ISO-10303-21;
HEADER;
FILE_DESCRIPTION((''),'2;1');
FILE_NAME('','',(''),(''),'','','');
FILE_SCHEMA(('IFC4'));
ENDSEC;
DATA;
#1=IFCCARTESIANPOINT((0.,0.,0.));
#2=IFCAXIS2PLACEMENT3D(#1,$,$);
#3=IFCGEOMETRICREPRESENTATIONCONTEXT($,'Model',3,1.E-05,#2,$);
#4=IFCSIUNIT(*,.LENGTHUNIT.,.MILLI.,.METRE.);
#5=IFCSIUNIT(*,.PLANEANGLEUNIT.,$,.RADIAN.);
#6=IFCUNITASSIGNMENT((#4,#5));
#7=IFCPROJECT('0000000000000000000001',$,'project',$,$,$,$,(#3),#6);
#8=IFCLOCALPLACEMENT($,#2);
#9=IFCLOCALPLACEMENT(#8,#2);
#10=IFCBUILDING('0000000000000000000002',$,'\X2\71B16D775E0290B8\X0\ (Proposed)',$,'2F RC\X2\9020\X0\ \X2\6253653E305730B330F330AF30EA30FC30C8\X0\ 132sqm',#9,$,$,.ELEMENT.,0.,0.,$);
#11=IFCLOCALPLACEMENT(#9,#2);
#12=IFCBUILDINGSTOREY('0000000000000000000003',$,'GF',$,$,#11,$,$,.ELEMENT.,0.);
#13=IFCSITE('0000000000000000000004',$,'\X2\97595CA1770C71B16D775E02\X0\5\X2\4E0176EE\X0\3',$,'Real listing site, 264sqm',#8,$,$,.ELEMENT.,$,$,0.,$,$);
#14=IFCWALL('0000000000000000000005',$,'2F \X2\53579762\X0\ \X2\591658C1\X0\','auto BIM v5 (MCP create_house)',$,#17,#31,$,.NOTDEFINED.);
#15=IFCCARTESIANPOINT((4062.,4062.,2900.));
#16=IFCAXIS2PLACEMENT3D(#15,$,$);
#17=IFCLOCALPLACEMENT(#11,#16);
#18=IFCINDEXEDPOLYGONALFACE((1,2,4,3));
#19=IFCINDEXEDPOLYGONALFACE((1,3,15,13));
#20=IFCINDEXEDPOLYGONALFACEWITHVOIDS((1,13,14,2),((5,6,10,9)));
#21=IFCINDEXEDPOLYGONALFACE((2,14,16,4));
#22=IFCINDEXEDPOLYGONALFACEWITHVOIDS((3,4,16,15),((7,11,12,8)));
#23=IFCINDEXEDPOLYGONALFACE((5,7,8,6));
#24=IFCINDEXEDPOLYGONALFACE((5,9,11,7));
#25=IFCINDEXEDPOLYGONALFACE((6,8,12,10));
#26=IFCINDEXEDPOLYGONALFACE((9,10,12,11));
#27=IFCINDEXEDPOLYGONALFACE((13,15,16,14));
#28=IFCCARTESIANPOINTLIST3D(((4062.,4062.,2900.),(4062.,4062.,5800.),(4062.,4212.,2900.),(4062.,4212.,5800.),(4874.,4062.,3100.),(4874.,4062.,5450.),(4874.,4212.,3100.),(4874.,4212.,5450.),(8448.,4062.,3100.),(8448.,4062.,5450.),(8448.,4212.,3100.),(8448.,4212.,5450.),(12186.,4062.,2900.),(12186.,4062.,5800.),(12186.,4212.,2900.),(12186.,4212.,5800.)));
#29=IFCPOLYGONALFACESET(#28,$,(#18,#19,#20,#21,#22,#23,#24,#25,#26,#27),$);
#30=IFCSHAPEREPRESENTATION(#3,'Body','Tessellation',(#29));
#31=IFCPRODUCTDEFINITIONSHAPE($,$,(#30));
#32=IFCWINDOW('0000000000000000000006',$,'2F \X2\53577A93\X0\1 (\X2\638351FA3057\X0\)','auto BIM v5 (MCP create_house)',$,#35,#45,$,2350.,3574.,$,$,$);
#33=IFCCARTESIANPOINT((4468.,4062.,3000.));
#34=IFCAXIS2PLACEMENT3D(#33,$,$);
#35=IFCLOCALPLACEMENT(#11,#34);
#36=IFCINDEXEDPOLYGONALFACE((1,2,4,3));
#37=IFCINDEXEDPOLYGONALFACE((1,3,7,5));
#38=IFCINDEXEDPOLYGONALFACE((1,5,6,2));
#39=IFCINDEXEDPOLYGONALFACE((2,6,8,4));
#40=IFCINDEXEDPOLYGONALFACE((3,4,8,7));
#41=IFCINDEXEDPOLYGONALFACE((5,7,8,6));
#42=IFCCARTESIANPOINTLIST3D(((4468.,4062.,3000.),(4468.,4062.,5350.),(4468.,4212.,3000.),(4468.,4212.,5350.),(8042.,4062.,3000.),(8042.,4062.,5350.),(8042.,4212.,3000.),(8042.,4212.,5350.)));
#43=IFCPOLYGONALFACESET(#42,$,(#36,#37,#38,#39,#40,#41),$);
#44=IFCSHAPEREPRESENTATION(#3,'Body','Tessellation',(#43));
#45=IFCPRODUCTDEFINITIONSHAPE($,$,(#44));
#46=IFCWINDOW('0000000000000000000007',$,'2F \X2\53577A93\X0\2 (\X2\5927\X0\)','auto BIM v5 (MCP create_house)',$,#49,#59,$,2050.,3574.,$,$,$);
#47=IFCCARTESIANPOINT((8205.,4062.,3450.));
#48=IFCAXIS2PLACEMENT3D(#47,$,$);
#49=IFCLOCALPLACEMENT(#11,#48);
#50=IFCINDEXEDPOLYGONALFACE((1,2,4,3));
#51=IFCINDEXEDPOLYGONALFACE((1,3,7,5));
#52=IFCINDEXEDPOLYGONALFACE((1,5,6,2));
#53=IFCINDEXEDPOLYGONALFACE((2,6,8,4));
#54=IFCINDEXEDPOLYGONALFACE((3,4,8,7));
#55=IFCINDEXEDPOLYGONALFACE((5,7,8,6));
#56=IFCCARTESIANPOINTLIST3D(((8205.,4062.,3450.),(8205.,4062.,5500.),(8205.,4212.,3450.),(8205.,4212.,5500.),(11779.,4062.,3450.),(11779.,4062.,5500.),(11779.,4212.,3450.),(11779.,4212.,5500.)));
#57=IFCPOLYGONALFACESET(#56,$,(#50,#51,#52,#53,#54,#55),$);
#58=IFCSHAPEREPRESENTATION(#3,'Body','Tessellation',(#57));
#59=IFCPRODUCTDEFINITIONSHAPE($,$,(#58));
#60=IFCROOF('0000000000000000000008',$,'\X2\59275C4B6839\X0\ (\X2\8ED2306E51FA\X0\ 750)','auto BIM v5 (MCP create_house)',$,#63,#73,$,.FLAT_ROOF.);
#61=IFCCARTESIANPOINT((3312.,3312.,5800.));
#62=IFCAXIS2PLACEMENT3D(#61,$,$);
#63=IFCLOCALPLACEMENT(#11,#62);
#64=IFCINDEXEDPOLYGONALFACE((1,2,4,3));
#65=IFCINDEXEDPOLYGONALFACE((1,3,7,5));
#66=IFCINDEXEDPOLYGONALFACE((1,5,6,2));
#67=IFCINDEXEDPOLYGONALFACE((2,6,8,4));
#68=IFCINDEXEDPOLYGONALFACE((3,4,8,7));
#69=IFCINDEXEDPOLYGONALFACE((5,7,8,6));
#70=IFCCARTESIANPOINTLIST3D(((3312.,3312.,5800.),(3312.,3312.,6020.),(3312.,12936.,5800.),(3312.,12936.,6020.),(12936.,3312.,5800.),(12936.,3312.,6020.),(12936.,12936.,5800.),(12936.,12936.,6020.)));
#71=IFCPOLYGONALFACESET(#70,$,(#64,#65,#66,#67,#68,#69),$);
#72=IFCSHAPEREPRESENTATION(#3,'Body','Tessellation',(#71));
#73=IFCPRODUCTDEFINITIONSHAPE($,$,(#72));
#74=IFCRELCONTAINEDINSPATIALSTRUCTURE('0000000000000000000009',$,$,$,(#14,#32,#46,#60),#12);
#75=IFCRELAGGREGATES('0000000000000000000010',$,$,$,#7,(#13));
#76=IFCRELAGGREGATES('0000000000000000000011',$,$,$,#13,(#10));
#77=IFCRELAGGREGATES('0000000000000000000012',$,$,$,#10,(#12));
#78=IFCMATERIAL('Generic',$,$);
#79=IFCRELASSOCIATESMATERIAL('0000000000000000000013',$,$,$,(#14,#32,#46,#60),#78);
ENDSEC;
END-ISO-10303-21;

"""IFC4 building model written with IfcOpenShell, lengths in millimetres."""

from ifc_helpers import new_model, si_unit, frame, frame_2d, origin, place, context, project, spatial, rectangle, extrude, material, element, fill, save


model = new_model("IFC4")

# Units and contexts
model_context = context("Model", 3, precision=1e-05, world=origin())
ifc_project = project(units=[si_unit("LENGTHUNIT", "METRE", prefix="MILLI"), si_unit("PLANEANGLEUNIT", "RADIAN")], contexts=[model_context])

# Site, building, storey
site_placement = place(None, origin())
site = spatial("IfcSite", under=ifc_project, at=site_placement, Name="静岡県熱海市5丁目3", ObjectType="Real listing site, 264sqm", CompositionType="ELEMENT", RefElevation=0.0)
building_placement = place(site_placement, origin())
building = spatial("IfcBuilding", under=site, at=building_placement, Name="熱海市邸 (Proposed)", ObjectType="2F RC造 打放しコンクリート 132sqm", CompositionType="ELEMENT", ElevationOfRefHeight=0.0, ElevationOfTerrain=0.0)
storey_placement = place(building_placement, origin())
storey = spatial("IfcBuildingStorey", under=building, at=storey_placement, Name="GF", CompositionType="ELEMENT", Elevation=0.0)

# Shared definitions
ifc_material = material(Name="Generic")

# Wall, openings, windows
wall_1_placement = place(storey_placement, frame((4062.0, 4062.0, 2900.0)))
wall_1 = element("IfcWall", 1, at=wall_1_placement, inside=storey, material=ifc_material, Name="2F 南面 外壁", Description="auto BIM v5 (MCP create_house)", PredefinedType="NOTDEFINED", context=model_context, shape_type="SweptSolid", body=[
    extrude(rectangle(XDim=8124.0, YDim=150.0, at=frame_2d((4062.0, 75.0))), frame((4062.0, 4062.0, 2900.0)), (0.0, 0.0, 1.0), 2900.0),
])
opening_1_placement = place(storey_placement, frame((4468.0, 4062.0, 3000.0)))
opening_1 = element("IfcOpeningElement", 2, at=opening_1_placement, cuts=wall_1, PredefinedType="NOTDEFINED", context=model_context, shape_type="SweptSolid", body=[
    extrude(rectangle(XDim=3574.0, YDim=150.0, at=frame_2d((1787.0, 75.0))), frame((4468.0, 4062.0, 3000.0)), (0.0, 0.0, 1.0), 2350.0),
])
opening_2_placement = place(storey_placement, frame((8205.0, 4062.0, 3450.0)))
opening_2 = element("IfcOpeningElement", 3, at=opening_2_placement, cuts=wall_1, PredefinedType="NOTDEFINED", context=model_context, shape_type="SweptSolid", body=[
    extrude(rectangle(XDim=3574.0, YDim=150.0, at=frame_2d((1787.0, 75.0))), frame((8205.0, 4062.0, 3450.0)), (0.0, 0.0, 1.0), 2050.0),
])
window_1_placement = place(storey_placement, frame((4468.0, 4062.0, 3000.0)))
window_1 = element("IfcWindow", 4, at=window_1_placement, inside=storey, material=ifc_material, Name="2F 南窓1 (掃出し)", Description="auto BIM v5 (MCP create_house)", OverallHeight=2350.0, OverallWidth=3574.0, context=model_context, shape_type="SweptSolid", body=[
    extrude(rectangle(XDim=3574.0, YDim=150.0, at=frame_2d((1787.0, 75.0))), frame((4468.0, 4062.0, 3000.0)), (0.0, 0.0, 1.0), 2350.0),
])
fill(opening_1, window_1)
window_2_placement = place(storey_placement, frame((8205.0, 4062.0, 3450.0)))
window_2 = element("IfcWindow", 5, at=window_2_placement, inside=storey, material=ifc_material, Name="2F 南窓2 (大)", Description="auto BIM v5 (MCP create_house)", OverallHeight=2050.0, OverallWidth=3574.0, context=model_context, shape_type="SweptSolid", body=[
    extrude(rectangle(XDim=3574.0, YDim=150.0, at=frame_2d((1787.0, 75.0))), frame((8205.0, 4062.0, 3450.0)), (0.0, 0.0, 1.0), 2050.0),
])
fill(opening_2, window_2)

# Roof
roof_placement = place(storey_placement, frame((3312.0, 3312.0, 5800.0)))
element("IfcRoof", 6, at=roof_placement, inside=storey, material=ifc_material, Name="大屋根 (軒の出 750)", Description="auto BIM v5 (MCP create_house)", PredefinedType="FLAT_ROOF", context=model_context, shape_type="SweptSolid", body=[
    extrude(rectangle(XDim=9624.0, YDim=9624.0, at=frame_2d((4812.0, 4812.0))), frame((3312.0, 3312.0, 5800.0)), (0.0, 0.0, 1.0), 220.0),
])

save(model, "model.ifc")
